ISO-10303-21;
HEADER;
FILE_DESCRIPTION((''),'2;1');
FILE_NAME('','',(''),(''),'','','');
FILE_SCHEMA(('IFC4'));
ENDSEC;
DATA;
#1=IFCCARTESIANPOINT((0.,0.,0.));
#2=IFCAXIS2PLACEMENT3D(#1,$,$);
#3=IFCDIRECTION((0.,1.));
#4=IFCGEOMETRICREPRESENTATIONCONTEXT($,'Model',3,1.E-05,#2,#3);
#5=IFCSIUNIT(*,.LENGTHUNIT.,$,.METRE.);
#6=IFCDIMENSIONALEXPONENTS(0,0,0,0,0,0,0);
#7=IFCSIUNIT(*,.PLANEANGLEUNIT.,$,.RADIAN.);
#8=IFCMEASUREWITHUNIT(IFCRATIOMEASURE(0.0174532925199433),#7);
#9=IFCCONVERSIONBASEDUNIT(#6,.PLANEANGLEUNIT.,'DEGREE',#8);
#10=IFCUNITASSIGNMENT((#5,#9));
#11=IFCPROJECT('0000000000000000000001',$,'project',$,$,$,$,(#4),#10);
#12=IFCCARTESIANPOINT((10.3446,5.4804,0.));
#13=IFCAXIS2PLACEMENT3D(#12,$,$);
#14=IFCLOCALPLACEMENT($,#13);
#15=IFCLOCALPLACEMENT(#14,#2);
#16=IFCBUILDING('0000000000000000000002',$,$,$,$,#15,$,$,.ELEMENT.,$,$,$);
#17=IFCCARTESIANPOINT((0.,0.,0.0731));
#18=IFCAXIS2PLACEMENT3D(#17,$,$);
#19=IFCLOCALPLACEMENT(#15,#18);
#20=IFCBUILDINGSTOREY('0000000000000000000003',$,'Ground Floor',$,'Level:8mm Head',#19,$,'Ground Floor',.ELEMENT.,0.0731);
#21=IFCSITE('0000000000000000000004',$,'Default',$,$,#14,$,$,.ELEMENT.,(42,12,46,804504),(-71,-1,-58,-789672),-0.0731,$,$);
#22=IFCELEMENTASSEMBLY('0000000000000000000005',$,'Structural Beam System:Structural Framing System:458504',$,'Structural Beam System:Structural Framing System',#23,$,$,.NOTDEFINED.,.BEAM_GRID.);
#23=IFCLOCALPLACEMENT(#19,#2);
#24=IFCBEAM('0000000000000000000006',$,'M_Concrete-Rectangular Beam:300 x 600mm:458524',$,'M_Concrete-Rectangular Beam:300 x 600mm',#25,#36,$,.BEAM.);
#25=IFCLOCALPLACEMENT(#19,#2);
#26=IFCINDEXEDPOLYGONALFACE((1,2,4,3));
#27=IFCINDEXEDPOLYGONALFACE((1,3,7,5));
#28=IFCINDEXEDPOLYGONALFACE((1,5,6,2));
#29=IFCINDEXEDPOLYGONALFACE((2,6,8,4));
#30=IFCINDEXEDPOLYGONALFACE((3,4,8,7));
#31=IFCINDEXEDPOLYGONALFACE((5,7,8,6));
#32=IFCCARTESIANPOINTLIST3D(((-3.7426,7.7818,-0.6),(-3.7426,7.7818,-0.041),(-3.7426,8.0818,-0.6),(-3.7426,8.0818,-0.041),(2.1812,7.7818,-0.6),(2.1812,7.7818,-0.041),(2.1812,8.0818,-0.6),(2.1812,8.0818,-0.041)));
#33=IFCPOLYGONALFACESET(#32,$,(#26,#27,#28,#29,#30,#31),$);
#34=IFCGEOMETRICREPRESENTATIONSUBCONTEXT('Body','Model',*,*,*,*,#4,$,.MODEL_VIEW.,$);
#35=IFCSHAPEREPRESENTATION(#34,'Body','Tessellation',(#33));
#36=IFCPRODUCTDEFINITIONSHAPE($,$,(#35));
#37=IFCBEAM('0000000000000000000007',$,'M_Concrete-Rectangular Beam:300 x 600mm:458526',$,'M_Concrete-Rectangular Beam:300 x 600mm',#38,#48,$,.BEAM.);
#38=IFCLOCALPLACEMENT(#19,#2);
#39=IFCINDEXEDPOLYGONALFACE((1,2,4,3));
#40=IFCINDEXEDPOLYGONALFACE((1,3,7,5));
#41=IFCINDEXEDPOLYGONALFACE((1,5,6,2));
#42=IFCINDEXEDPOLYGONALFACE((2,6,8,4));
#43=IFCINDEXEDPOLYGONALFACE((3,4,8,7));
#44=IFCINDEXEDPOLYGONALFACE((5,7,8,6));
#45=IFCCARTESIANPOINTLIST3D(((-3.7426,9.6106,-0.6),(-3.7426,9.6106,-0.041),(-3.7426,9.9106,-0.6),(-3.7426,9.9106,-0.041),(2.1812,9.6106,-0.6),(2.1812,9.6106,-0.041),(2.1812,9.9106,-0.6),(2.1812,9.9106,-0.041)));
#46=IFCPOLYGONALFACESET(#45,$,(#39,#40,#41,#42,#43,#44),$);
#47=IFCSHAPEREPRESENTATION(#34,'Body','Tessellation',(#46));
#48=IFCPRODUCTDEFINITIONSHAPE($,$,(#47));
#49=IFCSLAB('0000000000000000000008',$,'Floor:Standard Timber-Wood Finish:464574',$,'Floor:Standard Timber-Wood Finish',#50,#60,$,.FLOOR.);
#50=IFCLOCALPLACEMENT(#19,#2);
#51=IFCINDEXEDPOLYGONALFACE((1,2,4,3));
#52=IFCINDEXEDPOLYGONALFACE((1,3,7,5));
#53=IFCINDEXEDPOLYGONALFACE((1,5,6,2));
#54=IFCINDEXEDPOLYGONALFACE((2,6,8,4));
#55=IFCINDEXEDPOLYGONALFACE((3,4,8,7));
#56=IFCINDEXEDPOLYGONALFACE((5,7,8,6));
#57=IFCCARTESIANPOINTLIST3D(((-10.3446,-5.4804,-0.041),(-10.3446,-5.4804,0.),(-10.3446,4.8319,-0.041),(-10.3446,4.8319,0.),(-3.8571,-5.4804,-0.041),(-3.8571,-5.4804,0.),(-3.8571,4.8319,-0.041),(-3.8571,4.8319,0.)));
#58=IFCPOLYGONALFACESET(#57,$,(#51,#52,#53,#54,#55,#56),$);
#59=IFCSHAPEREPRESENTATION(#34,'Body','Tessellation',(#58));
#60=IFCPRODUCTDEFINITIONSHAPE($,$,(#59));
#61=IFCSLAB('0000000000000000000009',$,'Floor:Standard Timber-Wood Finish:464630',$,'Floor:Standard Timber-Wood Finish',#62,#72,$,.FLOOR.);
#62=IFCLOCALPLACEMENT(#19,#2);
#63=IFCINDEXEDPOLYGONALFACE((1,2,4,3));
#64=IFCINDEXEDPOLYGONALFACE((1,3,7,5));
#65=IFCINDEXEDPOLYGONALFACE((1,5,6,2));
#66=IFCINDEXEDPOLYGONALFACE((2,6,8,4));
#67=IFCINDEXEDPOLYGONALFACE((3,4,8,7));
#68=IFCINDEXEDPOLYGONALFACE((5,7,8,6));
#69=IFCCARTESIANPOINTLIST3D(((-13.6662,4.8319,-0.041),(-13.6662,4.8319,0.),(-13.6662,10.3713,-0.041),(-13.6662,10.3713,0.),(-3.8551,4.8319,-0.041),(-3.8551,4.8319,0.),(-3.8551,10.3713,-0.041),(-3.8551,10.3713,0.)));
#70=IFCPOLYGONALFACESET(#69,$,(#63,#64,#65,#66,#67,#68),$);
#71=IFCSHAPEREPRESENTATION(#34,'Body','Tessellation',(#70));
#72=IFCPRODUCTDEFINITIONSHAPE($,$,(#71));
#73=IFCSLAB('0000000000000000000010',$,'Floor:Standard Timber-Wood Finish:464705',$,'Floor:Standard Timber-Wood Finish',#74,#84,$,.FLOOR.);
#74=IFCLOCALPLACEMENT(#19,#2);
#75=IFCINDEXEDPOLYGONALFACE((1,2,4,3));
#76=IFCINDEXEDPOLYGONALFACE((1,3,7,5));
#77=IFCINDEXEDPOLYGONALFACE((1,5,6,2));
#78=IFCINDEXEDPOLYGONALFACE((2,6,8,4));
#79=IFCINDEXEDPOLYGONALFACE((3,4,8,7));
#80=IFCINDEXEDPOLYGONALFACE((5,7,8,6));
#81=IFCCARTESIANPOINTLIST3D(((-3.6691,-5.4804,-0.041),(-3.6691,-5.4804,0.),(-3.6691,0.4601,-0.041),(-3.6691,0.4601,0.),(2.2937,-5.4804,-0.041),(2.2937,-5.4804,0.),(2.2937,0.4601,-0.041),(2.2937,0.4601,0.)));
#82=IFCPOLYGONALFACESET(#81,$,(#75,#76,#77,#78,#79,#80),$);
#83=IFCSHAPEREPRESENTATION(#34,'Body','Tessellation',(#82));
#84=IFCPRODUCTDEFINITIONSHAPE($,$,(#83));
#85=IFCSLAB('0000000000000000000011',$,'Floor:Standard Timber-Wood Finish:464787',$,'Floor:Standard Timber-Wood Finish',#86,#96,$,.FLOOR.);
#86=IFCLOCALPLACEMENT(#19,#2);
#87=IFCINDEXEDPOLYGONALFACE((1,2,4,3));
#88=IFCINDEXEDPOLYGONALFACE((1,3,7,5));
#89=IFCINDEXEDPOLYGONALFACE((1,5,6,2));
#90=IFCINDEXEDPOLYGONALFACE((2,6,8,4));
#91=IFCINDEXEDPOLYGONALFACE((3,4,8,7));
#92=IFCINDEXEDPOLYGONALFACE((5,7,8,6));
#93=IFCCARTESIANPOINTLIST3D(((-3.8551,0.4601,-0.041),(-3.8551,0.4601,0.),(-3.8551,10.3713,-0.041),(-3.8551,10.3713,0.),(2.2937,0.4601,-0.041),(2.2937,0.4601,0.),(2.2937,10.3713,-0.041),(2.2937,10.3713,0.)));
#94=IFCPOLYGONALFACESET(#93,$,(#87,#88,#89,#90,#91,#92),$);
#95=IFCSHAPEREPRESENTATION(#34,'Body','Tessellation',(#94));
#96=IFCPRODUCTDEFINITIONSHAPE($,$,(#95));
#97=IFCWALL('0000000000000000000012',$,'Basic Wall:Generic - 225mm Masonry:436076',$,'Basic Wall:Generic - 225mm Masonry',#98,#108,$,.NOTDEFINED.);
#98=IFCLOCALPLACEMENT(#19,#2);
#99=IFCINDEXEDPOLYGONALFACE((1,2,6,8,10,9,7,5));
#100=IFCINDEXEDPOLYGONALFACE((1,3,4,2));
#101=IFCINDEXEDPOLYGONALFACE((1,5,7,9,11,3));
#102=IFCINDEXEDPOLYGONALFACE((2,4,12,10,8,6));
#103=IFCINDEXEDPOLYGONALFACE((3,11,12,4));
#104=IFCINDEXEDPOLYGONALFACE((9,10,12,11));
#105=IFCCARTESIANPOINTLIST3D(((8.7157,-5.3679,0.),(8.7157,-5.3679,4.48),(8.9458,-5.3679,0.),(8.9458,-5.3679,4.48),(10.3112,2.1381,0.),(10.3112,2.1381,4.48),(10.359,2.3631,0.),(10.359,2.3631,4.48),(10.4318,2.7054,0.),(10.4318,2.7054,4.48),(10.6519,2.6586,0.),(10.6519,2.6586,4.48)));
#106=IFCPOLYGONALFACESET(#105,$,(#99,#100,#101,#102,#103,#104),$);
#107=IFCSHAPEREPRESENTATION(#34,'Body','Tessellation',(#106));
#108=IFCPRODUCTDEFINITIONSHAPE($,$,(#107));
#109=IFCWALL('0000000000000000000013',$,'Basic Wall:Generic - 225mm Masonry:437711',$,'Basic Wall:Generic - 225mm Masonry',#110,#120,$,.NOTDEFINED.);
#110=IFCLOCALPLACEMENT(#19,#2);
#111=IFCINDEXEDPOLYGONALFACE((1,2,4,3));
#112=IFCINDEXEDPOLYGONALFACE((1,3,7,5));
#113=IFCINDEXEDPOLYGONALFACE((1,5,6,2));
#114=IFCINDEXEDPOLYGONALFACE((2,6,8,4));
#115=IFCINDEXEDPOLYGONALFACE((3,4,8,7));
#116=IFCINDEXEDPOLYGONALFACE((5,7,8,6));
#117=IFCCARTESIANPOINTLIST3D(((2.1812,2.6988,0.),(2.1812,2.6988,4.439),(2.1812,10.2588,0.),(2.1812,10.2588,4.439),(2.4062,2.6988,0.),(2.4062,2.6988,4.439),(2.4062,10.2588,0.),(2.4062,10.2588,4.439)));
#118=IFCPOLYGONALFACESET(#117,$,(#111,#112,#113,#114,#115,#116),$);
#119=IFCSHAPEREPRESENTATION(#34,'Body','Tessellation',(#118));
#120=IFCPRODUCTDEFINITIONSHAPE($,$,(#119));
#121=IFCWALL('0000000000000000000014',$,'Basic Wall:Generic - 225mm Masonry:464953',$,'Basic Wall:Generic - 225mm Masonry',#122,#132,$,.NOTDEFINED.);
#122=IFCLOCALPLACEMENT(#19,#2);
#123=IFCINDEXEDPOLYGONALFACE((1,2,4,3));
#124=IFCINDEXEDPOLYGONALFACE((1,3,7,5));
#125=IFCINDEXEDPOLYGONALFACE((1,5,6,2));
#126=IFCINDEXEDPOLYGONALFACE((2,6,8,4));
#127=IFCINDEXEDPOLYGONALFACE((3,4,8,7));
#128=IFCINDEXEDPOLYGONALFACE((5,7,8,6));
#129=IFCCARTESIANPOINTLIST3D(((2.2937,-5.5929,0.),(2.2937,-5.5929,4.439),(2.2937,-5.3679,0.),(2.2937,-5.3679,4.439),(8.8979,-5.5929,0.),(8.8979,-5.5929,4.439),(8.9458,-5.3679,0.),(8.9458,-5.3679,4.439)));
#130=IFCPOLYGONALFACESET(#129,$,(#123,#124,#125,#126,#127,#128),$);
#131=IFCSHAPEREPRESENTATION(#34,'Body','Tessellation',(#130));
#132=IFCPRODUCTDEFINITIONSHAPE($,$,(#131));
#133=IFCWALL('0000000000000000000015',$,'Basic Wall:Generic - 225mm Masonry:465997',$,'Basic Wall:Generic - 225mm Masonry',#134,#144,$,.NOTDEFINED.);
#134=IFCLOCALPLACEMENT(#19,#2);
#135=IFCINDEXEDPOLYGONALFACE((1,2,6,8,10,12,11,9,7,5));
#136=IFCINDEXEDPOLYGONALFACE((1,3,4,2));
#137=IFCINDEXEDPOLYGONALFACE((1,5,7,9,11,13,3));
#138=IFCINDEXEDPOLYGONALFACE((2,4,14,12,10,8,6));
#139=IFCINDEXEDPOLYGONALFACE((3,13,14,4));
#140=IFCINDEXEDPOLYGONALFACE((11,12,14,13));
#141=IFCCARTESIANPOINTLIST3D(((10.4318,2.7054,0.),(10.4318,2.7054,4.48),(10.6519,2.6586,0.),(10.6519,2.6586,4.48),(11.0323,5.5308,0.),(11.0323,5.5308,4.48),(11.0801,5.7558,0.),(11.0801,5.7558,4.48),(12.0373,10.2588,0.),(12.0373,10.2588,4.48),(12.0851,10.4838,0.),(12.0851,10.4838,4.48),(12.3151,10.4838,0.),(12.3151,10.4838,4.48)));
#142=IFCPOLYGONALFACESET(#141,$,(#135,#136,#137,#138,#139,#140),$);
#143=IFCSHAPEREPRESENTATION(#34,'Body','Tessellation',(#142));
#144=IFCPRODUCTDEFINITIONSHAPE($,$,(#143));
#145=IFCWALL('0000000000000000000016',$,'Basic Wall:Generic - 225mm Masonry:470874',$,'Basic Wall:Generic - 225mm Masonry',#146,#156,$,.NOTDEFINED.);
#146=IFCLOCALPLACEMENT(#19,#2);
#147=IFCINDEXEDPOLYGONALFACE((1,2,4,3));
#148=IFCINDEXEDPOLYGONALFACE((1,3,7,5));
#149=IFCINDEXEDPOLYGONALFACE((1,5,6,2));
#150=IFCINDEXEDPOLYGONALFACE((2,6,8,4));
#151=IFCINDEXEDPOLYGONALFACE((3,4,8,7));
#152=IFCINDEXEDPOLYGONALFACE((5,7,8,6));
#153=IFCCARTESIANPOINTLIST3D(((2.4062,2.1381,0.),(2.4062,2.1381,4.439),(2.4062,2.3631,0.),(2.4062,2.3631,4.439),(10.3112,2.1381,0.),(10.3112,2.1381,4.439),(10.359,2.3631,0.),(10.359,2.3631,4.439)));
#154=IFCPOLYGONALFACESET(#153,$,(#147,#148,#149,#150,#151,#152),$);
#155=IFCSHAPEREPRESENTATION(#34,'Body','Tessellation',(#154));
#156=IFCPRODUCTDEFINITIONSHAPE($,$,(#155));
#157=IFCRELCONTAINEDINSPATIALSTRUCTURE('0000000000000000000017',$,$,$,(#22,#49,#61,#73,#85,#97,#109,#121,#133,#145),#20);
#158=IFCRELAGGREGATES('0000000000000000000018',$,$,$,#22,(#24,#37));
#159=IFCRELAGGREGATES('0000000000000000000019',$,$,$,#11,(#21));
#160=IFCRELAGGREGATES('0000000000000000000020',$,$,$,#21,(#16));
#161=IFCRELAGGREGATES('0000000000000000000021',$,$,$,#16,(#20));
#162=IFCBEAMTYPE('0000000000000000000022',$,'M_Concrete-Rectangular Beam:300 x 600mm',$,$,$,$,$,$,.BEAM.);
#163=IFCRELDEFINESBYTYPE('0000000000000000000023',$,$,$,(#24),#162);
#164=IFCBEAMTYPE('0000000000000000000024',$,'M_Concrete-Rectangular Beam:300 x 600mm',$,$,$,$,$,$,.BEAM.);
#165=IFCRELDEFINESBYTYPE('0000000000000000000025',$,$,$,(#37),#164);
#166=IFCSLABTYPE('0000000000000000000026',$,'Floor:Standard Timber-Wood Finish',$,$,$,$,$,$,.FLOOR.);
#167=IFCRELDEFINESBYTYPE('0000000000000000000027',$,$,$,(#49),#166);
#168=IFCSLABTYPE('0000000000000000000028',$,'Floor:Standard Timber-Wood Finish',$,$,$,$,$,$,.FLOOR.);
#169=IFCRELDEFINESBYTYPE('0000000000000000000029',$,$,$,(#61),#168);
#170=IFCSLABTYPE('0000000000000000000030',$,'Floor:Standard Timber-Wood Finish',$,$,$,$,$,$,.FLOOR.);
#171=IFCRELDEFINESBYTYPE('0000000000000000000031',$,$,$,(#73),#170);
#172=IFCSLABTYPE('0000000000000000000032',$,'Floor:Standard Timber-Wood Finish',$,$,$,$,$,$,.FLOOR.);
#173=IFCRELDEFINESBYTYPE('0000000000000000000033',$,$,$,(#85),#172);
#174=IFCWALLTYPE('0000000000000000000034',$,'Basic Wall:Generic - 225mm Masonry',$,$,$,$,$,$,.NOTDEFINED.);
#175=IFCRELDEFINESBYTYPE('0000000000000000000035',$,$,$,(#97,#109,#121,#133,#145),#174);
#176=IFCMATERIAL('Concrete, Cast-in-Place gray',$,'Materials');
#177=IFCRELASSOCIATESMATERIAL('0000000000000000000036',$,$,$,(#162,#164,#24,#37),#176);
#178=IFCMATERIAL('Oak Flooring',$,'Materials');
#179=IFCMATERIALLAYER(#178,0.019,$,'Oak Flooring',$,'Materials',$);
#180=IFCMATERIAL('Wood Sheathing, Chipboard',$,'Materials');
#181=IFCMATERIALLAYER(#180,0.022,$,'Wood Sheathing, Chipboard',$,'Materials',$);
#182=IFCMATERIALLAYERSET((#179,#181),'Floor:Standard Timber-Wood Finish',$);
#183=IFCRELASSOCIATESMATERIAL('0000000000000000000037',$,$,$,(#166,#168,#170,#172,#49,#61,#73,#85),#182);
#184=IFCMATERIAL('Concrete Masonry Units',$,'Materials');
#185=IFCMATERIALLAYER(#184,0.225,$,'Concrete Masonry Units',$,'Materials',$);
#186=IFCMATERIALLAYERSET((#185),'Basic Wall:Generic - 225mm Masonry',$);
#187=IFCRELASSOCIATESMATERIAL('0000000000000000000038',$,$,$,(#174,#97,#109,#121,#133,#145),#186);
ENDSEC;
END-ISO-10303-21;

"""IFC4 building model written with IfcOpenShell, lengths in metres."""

from ifc_helpers import new_model, entity, si_unit, converted_unit, direction, frame, frame_2d, origin, origin_2d_with_axis, place, context, subcontext, project, spatial, polyline, rectangle, outline, extrude, clip, bounded_halfspace, source, transform, mapped, material, layer, layer_set, layer_usage, material_profile, profile_set, profile_usage, type_object, type_shapes, element, aggregate, save


model = new_model("IFC4")

# Units and contexts
model_context = context("Model", 3, precision=1e-05, world=origin(), true_north=direction((0.0, 1.0)))
body_context = subcontext(model_context, "Body", "Model", "MODEL_VIEW")
ifc_project = project(units=[si_unit("LENGTHUNIT", "METRE"), converted_unit("PLANEANGLEUNIT", "DEGREE", entity("IfcRatioMeasure", 0.0174532925199433), si_unit("PLANEANGLEUNIT", "RADIAN"), dimensions=[0, 0, 0, 0, 0, 0, 0])], contexts=[model_context])

# Site, building, storey
site_placement = place(None, frame((10.3446, 5.4804, 0.0)))
site = spatial("IfcSite", under=ifc_project, at=site_placement, Name="Default", CompositionType="ELEMENT", RefLatitude=(42, 12, 46, 804504), RefLongitude=(-71, -1, -58, -789672), RefElevation=-0.0731)
building_placement = place(site_placement, origin())
building = spatial("IfcBuilding", under=site, at=building_placement, CompositionType="ELEMENT")
storey_placement = place(building_placement, frame((0.0, 0.0, 0.0731)))
storey = spatial("IfcBuildingStorey", under=building, at=storey_placement, Name="Ground Floor", ObjectType="Level:8mm Head", LongName="Ground Floor", CompositionType="ELEMENT", Elevation=0.0731)

# Element assembly, beams
assembly_1_placement = place(storey_placement, origin())
assembly_1 = element("IfcElementAssembly", 1, at=assembly_1_placement, inside=storey, Name="Structural Beam System:Structural Framing System:458504", ObjectType="Structural Beam System:Structural Framing System", AssemblyPlace="NOTDEFINED", PredefinedType="BEAM_GRID")
ifc_material_1 = material(Name="Concrete, Cast-in-Place gray", Category="Materials")
ifc_material_profile = material_profile(ifc_material_1, rectangle(XDim=0.559, YDim=0.3, at=frame_2d((0.0, 0.0), x_axis=(1.0, 0.0))), Name="300 x 600mm")
ifc_profile_set = profile_set([ifc_material_profile], Name="300 x 600mm")
ifc_profile_usage_1 = profile_usage(ifc_profile_set, cardinal=8)
beam_type_1 = type_object("IfcBeamType", Name="M_Concrete-Rectangular Beam:300 x 600mm", PredefinedType="BEAM", material=ifc_profile_set)
shared_shape_1 = source(origin(), body_context, "Body", "SweptSolid", [
    extrude(rectangle(XDim=0.559, YDim=0.3, at=frame_2d((0.0, 0.0), x_axis=(1.0, 0.0))), frame((2.1812, 7.9318, -0.2474), z_axis=(-1.0, 0.0, 0.0), x_axis=(0.0, 0.0, -1.0)), (0.0, 0.0, 1.0), 5.9238),
])
type_shapes(beam_type_1, [shared_shape_1])
beam_1_placement = place(assembly_1_placement, frame((0.0, 0.0, -0.0731)))
beam_1 = element("IfcBeam", 2, at=beam_1_placement, type_object=beam_type_1, material=ifc_profile_usage_1, Name="M_Concrete-Rectangular Beam:300 x 600mm:458524", ObjectType="M_Concrete-Rectangular Beam:300 x 600mm", PredefinedType="BEAM", context=body_context, shape_type="MappedRepresentation", body=[
    mapped(shared_shape_1, transform((0.0, 0.0, 0.0), scale=1.0)),
])
ifc_profile_usage_2 = profile_usage(ifc_profile_set, cardinal=8)
beam_type_2 = type_object("IfcBeamType", Name="M_Concrete-Rectangular Beam:300 x 600mm", PredefinedType="BEAM", material=ifc_profile_set)
shared_shape_2 = source(origin(), body_context, "Body", "SweptSolid", [
    extrude(rectangle(XDim=0.559, YDim=0.3, at=frame_2d((0.0, 0.0), x_axis=(1.0, 0.0))), frame((2.1812, 9.7606, -0.2474), z_axis=(-1.0, 0.0, 0.0), x_axis=(0.0, 0.0, -1.0)), (0.0, 0.0, 1.0), 5.9238),
])
type_shapes(beam_type_2, [shared_shape_2])
beam_2_placement = place(assembly_1_placement, frame((0.0, 0.0, -0.0731)))
beam_2 = element("IfcBeam", 3, at=beam_2_placement, type_object=beam_type_2, material=ifc_profile_usage_2, Name="M_Concrete-Rectangular Beam:300 x 600mm:458526", ObjectType="M_Concrete-Rectangular Beam:300 x 600mm", PredefinedType="BEAM", context=body_context, shape_type="MappedRepresentation", body=[
    mapped(shared_shape_2, transform((0.0, 0.0, 0.0), scale=1.0)),
])
aggregate(assembly_1, [beam_1, beam_2])

# Slabs
ifc_material_2 = material(Name="Oak Flooring", Category="Materials")
ifc_layer_1 = layer(ifc_material_2, 0.019, Name="Oak Flooring", Category="Materials")
ifc_material_3 = material(Name="Wood Sheathing, Chipboard", Category="Materials")
ifc_layer_2 = layer(ifc_material_3, 0.022, Name="Wood Sheathing, Chipboard", Category="Materials")
ifc_layer_set_1 = layer_set([ifc_layer_1, ifc_layer_2], Name="Floor:Standard Timber-Wood Finish")
ifc_layer_usage_1 = layer_usage(ifc_layer_set_1, "AXIS3", "POSITIVE", 0.0)
slab_type_1 = type_object("IfcSlabType", Name="Floor:Standard Timber-Wood Finish", PredefinedType="FLOOR", material=ifc_layer_set_1)
slab_1_placement = place(storey_placement, origin())
element("IfcSlab", 4, at=slab_1_placement, inside=storey, type_object=slab_type_1, material=ifc_layer_usage_1, Name="Floor:Standard Timber-Wood Finish:464574", ObjectType="Floor:Standard Timber-Wood Finish", PredefinedType="FLOOR", context=body_context, shape_type="SweptSolid", body=[
    extrude(rectangle(XDim=10.3123, YDim=6.4875, at=frame_2d((0.0, 0.0), x_axis=(1.0, 0.0))), frame((-7.1009, -0.3243, 0.0), z_axis=(0.0, 0.0, -1.0), x_axis=(0.0, 1.0, 0.0)), (0.0, 0.0, 1.0), 0.041),
])
ifc_layer_usage_2 = layer_usage(ifc_layer_set_1, "AXIS3", "POSITIVE", 0.0)
slab_type_2 = type_object("IfcSlabType", Name="Floor:Standard Timber-Wood Finish", PredefinedType="FLOOR", material=ifc_layer_set_1)
slab_2_placement = place(storey_placement, origin())
element("IfcSlab", 5, at=slab_2_placement, inside=storey, type_object=slab_type_2, material=ifc_layer_usage_2, Name="Floor:Standard Timber-Wood Finish:464630", ObjectType="Floor:Standard Timber-Wood Finish", PredefinedType="FLOOR", context=body_context, shape_type="SweptSolid", body=[
    extrude(rectangle(XDim=5.5394, YDim=9.8111, at=origin_2d_with_axis()), frame((-8.7607, 7.6016, 0.0), z_axis=(0.0, 0.0, -1.0), x_axis=(0.0, 1.0, 0.0)), (0.0, 0.0, 1.0), 0.041),
])
ifc_layer_usage_3 = layer_usage(ifc_layer_set_1, "AXIS3", "POSITIVE", 0.0)
slab_type_3 = type_object("IfcSlabType", Name="Floor:Standard Timber-Wood Finish", PredefinedType="FLOOR", material=ifc_layer_set_1)
slab_3_placement = place(storey_placement, origin())
element("IfcSlab", 6, at=slab_3_placement, inside=storey, type_object=slab_type_3, material=ifc_layer_usage_3, Name="Floor:Standard Timber-Wood Finish:464705", ObjectType="Floor:Standard Timber-Wood Finish", PredefinedType="FLOOR", context=body_context, shape_type="SweptSolid", body=[
    extrude(rectangle(XDim=5.9405, YDim=5.9627, at=origin_2d_with_axis()), frame((-0.6877, -2.5102, 0.0), z_axis=(0.0, 0.0, -1.0), x_axis=(0.0, 1.0, 0.0)), (0.0, 0.0, 1.0), 0.041),
])
ifc_layer_usage_4 = layer_usage(ifc_layer_set_1, "AXIS3", "POSITIVE", 0.0)
slab_type_4 = type_object("IfcSlabType", Name="Floor:Standard Timber-Wood Finish", PredefinedType="FLOOR", material=ifc_layer_set_1)
slab_4_placement = place(storey_placement, origin())
element("IfcSlab", 7, at=slab_4_placement, inside=storey, type_object=slab_type_4, material=ifc_layer_usage_4, Name="Floor:Standard Timber-Wood Finish:464787", ObjectType="Floor:Standard Timber-Wood Finish", PredefinedType="FLOOR", context=body_context, shape_type="SweptSolid", body=[
    extrude(rectangle(XDim=9.9112, YDim=6.1488, at=frame_2d((0.0, 0.0), x_axis=(1.0, 0.0))), frame((-0.7807, 5.4157, 0.0), z_axis=(0.0, 0.0, -1.0), x_axis=(0.0, 1.0, 0.0)), (0.0, 0.0, 1.0), 0.041),
])

# Walls
ifc_material_4 = material(Name="Concrete Masonry Units", Category="Materials")
ifc_layer_3 = layer(ifc_material_4, 0.225, Name="Concrete Masonry Units", Category="Materials")
ifc_layer_set_2 = layer_set([ifc_layer_3], Name="Basic Wall:Generic - 225mm Masonry")
ifc_layer_usage_5 = layer_usage(ifc_layer_set_2, "AXIS2", "NEGATIVE", 0.1125)
wall_type = type_object("IfcWallType", Name="Basic Wall:Generic - 225mm Masonry", PredefinedType="NOTDEFINED", material=ifc_layer_set_2)
wall_1_placement = place(storey_placement, frame((8.8258, -5.3913, 0.0), z_axis=(0.0, 0.0, 1.0), x_axis=(0.207912, 0.978148, 0.0)))
element("IfcWall", 8, at=wall_1_placement, inside=storey, type_object=wall_type, material=ifc_layer_usage_5, Name="Basic Wall:Generic - 225mm Masonry:436076", ObjectType="Basic Wall:Generic - 225mm Masonry", PredefinedType="NOTDEFINED", context=body_context, shape_type="SweptSolid", body=[
    extrude(outline(polyline([(8.2537, -0.1125), (8.2537, 0.1125), (7.9038, 0.1125), (7.6738, 0.1125), (0.0, 0.1125), (0.0478, -0.1125), (8.2537, -0.1125)])), origin(), (0.0, 0.0, 1.0), 4.48),
])
ifc_layer_usage_6 = layer_usage(ifc_layer_set_2, "AXIS2", "NEGATIVE", 0.1125)
wall_2_placement = place(storey_placement, frame((2.2937, 10.2588, 0.0), z_axis=(0.0, 0.0, 1.0), x_axis=(0.0, -1.0, 0.0)))
element("IfcWall", 9, at=wall_2_placement, inside=storey, type_object=wall_type, material=ifc_layer_usage_6, Name="Basic Wall:Generic - 225mm Masonry:437711", ObjectType="Basic Wall:Generic - 225mm Masonry", PredefinedType="NOTDEFINED", context=body_context, shape_type="Clipping", body=[
    clip(extrude(rectangle(XDim=7.56, YDim=0.225, at=frame_2d((3.78, 0.0), x_axis=(-1.0, 0.0))), origin(), (0.0, 0.0, 1.0), 4.439), bounded_halfspace(frame((7.56, 0.0, 4.439), z_axis=(0.0, 0.0, -1.0), x_axis=(0.978148, -0.207912, 0.0)), True, frame((7.56, 0.0, 4.439)), polyline([(0.0, 0.0), (0.0, 0.1125), (-7.56, 0.1125), (-7.56, 0.0), (0.0, 0.0)]))),
])
ifc_layer_usage_7 = layer_usage(ifc_layer_set_2, "AXIS2", "NEGATIVE", 0.1125)
wall_3_placement = place(storey_placement, frame((2.2937, -5.4804, 0.0)))
element("IfcWall", 10, at=wall_3_placement, inside=storey, type_object=wall_type, material=ifc_layer_usage_7, Name="Basic Wall:Generic - 225mm Masonry:464953", ObjectType="Basic Wall:Generic - 225mm Masonry", PredefinedType="NOTDEFINED", context=body_context, shape_type="Clipping", body=[
    clip(extrude(outline(polyline([(6.6043, -0.1125), (6.6521, 0.1125), (6.4221, 0.1125), (0.1125, 0.1125), (0.0, 0.1125), (0.0, -0.1125), (6.6043, -0.1125)])), origin(), (0.0, 0.0, 1.0), 4.439), bounded_halfspace(frame((6.5371, 0.1125, 4.439), z_axis=(0.0, 0.0, -1.0), x_axis=(-1.0, 0.0, 0.0)), True, frame((6.5371, 0.1125, 4.439)), polyline([(0.0, 0.0), (-6.4246, 0.0), (-6.5371, 0.0), (-6.5371, -0.1125), (-0.0239, -0.1125), (0.0, 0.0)]))),
])
ifc_layer_usage_8 = layer_usage(ifc_layer_set_2, "AXIS2", "NEGATIVE", 0.1125)
wall_4_placement = place(storey_placement, frame((10.5418, 2.682, 0.0), z_axis=(0.0, 0.0, 1.0), x_axis=(0.207912, 0.978148, 0.0)))
element("IfcWall", 11, at=wall_4_placement, inside=storey, type_object=wall_type, material=ifc_layer_usage_8, Name="Basic Wall:Generic - 225mm Masonry:465997", ObjectType="Basic Wall:Generic - 225mm Masonry", PredefinedType="NOTDEFINED", context=body_context, shape_type="SweptSolid", body=[
    extrude(outline(polyline([(8.0, -0.1125), (7.9522, 0.1125), (7.7221, 0.1125), (3.1185, 0.1125), (2.8885, 0.1125), (0.0, 0.1125), (0.0, -0.1125), (8.0, -0.1125)])), origin(), (0.0, 0.0, 1.0), 4.48),
])
ifc_layer_usage_9 = layer_usage(ifc_layer_set_2, "AXIS2", "NEGATIVE", 0.1125)
wall_5_placement = place(storey_placement, frame((2.4062, 2.2506, 0.0)))
element("IfcWall", 12, at=wall_5_placement, inside=storey, type_object=wall_type, material=ifc_layer_usage_9, Name="Basic Wall:Generic - 225mm Masonry:470874", ObjectType="Basic Wall:Generic - 225mm Masonry", PredefinedType="NOTDEFINED", context=body_context, shape_type="Clipping", body=[
    clip(extrude(outline(polyline([(7.905, -0.1125), (7.9529, 0.1125), (0.0, 0.1125), (0.0, -0.1125), (7.905, -0.1125)])), origin(), (0.0, 0.0, 1.0), 4.439), bounded_halfspace(frame((0.0, -0.1125, 4.439), z_axis=(0.0, 0.0, -1.0), x_axis=(-1.0, 0.0, 0.0)), True, frame((0.0, -0.1125, 4.439)), polyline([(0.0, 0.0), (7.905, 0.0), (7.9529, 0.225), (0.0, 0.225), (0.0, 0.0)]))),
])

save(model, "model.ifc")
